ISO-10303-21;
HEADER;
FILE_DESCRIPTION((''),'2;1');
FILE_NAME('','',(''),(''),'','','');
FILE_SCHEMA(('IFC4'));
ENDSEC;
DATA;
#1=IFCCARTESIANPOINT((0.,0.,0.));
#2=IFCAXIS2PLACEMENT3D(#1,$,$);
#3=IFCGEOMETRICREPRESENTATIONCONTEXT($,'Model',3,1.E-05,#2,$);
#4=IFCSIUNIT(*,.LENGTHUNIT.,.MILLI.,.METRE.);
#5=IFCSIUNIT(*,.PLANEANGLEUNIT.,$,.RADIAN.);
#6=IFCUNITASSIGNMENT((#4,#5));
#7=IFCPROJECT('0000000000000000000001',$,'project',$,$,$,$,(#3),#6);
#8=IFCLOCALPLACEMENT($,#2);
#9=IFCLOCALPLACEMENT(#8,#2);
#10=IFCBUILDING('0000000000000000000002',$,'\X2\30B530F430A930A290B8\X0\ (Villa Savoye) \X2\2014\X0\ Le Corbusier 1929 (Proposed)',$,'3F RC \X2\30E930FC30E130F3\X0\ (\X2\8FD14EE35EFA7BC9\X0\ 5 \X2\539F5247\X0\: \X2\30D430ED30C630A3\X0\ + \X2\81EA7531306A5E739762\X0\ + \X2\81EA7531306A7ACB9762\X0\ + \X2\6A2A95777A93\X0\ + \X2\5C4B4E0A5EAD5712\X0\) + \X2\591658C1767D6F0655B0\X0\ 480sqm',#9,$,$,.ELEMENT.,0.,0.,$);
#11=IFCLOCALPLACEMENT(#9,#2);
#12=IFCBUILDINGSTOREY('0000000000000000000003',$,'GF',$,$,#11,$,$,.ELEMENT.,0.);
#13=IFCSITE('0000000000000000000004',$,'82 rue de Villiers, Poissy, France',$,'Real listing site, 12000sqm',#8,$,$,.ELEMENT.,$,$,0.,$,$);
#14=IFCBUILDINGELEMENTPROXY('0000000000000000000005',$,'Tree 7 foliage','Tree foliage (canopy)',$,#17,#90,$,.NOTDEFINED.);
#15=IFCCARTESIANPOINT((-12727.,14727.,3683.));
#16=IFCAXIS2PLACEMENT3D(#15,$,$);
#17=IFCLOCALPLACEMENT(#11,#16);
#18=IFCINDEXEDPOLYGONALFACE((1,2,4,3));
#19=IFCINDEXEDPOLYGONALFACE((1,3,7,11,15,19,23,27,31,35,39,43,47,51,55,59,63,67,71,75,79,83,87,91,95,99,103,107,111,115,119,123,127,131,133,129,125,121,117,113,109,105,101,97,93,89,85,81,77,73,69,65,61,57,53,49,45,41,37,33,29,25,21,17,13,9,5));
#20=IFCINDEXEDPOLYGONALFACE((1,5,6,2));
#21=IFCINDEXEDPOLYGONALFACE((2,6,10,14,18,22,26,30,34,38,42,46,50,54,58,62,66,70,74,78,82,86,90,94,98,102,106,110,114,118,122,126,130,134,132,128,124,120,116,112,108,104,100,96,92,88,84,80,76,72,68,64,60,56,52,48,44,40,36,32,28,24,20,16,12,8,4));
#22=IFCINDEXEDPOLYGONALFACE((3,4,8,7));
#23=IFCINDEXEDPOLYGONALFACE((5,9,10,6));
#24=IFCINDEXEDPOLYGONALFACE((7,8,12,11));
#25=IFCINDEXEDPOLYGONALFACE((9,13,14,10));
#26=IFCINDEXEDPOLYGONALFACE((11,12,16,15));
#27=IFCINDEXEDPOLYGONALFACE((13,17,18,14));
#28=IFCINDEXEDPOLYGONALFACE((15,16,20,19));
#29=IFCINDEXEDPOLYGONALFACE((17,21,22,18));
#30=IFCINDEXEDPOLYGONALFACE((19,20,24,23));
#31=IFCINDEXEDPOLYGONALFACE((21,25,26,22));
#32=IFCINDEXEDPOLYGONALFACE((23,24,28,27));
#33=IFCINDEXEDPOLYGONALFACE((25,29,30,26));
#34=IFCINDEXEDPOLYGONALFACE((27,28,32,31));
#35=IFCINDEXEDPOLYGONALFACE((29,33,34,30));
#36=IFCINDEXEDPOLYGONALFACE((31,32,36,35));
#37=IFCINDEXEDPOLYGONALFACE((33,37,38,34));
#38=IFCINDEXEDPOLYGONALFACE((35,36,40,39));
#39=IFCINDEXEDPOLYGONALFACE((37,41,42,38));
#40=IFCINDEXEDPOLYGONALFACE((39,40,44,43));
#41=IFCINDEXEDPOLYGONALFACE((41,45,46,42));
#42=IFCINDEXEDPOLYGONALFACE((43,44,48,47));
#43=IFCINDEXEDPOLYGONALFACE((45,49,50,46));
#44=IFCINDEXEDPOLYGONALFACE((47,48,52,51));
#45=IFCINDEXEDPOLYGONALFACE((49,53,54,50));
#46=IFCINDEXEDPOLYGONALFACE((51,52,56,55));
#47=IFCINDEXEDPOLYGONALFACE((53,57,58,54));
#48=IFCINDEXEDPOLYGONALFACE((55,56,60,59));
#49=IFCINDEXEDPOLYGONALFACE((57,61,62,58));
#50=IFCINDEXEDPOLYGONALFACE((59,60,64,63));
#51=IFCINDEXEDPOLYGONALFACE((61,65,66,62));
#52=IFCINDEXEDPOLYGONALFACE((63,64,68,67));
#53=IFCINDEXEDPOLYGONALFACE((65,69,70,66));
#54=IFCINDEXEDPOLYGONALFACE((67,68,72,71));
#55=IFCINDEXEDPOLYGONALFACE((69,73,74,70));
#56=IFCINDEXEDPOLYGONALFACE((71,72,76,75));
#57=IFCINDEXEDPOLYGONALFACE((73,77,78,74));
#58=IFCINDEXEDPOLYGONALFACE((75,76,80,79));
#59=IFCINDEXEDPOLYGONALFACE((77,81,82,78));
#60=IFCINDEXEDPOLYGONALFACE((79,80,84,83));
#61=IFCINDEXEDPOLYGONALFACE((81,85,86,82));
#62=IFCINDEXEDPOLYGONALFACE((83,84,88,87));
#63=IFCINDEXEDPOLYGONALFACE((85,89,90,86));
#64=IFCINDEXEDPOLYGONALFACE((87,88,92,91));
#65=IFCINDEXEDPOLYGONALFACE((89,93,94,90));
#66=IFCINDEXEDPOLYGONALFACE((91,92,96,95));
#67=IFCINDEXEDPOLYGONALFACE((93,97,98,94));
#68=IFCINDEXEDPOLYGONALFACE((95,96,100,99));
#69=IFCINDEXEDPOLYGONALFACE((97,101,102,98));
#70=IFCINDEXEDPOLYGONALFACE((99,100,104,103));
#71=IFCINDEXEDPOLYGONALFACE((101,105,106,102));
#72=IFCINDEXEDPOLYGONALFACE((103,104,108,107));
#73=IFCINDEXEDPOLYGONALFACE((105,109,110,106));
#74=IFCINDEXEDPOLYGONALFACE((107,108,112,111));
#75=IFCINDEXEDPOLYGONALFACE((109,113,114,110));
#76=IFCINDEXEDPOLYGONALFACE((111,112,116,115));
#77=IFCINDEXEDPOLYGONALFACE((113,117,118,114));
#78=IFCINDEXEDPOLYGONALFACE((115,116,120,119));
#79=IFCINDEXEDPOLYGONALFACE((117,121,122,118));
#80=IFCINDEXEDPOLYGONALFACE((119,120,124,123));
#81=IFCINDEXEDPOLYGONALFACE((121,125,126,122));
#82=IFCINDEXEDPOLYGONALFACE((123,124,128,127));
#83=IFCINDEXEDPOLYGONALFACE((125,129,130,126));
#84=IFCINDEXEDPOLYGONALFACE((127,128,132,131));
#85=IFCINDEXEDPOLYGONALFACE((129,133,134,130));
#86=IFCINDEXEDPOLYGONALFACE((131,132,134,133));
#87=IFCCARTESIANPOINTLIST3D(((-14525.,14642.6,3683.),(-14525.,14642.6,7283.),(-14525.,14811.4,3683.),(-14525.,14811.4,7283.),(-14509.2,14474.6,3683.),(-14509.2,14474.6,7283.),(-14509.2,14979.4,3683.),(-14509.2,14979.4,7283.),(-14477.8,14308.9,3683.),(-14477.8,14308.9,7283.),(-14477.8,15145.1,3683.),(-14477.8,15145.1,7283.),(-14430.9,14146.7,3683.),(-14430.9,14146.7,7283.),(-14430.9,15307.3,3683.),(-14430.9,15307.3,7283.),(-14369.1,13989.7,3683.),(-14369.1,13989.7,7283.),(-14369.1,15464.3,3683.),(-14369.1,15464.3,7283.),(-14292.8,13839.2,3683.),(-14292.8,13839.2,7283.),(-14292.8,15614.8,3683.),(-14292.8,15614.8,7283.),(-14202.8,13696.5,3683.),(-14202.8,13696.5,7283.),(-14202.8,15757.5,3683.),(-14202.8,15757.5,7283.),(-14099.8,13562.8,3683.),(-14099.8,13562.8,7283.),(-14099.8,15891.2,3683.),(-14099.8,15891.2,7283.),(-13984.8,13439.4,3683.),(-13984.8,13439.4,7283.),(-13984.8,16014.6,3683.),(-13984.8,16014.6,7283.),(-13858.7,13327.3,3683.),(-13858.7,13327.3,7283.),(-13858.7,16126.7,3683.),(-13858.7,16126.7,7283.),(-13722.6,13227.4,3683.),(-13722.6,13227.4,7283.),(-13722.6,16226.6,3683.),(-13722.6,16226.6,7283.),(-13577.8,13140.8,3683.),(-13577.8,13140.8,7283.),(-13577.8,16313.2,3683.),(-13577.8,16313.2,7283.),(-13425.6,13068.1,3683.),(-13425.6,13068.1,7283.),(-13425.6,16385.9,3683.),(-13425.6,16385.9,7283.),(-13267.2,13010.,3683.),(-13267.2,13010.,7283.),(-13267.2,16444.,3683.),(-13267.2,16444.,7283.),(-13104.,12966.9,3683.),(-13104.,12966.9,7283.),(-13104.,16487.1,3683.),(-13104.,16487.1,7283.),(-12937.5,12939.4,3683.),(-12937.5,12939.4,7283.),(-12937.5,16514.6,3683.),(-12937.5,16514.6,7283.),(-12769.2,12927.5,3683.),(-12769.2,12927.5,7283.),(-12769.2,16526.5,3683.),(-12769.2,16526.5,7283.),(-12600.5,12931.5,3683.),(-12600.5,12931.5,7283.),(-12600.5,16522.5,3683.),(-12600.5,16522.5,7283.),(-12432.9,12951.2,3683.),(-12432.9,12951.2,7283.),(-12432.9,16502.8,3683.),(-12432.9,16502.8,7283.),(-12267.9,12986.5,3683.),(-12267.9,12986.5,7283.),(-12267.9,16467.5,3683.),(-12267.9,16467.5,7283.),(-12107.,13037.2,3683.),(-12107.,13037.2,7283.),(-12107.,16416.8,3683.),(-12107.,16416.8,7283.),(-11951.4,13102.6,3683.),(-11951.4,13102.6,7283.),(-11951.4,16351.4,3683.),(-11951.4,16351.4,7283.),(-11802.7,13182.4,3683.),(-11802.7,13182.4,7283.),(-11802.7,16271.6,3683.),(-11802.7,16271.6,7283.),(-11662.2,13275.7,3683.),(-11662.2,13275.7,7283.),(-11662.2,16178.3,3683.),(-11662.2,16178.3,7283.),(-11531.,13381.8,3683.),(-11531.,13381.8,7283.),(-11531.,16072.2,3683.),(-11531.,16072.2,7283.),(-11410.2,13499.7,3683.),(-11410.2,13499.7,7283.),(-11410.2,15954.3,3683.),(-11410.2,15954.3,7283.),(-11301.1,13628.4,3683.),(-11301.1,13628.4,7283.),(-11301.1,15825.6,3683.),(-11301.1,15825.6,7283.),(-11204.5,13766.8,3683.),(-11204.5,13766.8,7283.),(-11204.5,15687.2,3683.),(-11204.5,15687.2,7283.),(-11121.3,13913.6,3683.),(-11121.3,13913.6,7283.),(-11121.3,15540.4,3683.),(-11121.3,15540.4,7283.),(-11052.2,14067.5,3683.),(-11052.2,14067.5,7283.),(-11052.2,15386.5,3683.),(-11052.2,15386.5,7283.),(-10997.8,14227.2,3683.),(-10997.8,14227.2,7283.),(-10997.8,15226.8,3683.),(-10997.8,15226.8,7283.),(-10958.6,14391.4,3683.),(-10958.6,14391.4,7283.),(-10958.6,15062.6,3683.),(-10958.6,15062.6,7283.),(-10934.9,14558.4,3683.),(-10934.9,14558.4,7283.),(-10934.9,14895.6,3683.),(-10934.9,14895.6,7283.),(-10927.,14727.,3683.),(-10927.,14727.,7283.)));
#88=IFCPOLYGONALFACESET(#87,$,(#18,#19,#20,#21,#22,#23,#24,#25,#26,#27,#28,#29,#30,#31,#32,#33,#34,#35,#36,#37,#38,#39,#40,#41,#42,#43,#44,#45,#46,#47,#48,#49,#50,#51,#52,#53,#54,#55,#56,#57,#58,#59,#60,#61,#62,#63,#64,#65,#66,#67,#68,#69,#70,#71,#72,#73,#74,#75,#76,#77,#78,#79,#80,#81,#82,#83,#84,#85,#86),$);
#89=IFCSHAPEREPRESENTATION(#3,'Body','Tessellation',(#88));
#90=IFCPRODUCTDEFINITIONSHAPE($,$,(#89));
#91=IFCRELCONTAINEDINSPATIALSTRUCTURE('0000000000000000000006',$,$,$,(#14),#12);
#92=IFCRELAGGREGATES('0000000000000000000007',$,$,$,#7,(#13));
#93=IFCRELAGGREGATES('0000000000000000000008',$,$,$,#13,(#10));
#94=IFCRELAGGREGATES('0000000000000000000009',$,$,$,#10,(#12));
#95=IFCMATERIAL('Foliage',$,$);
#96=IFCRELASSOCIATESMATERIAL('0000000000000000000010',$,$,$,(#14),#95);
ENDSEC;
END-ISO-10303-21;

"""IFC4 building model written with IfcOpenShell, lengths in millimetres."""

from ifc_helpers import new_model, si_unit, frame, origin, origin_2d, place, context, project, spatial, circle, extrude, material, element, save


model = new_model("IFC4")

# Units and contexts
model_context = context("Model", 3, precision=1e-05, world=origin())
ifc_project = project(units=[si_unit("LENGTHUNIT", "METRE", prefix="MILLI"), si_unit("PLANEANGLEUNIT", "RADIAN")], contexts=[model_context])

# Site, building, storey
site_placement = place(None, origin())
site = spatial("IfcSite", under=ifc_project, at=site_placement, Name="82 rue de Villiers, Poissy, France", ObjectType="Real listing site, 12000sqm", CompositionType="ELEMENT", RefElevation=0.0)
building_placement = place(site_placement, origin())
building = spatial("IfcBuilding", under=site, at=building_placement, Name="サヴォア邸 (Villa Savoye) — Le Corbusier 1929 (Proposed)", ObjectType="3F RC ラーメン (近代建築 5 原則: ピロティ + 自由な平面 + 自由な立面 + 横長窓 + 屋上庭園) + 外壁白漆喰 480sqm", CompositionType="ELEMENT", ElevationOfRefHeight=0.0, ElevationOfTerrain=0.0)
storey_placement = place(building_placement, origin())
storey = spatial("IfcBuildingStorey", under=building, at=storey_placement, Name="GF", CompositionType="ELEMENT", Elevation=0.0)

# Building element proxy
ifc_material_1 = material(Name="Foliage")
proxy_1_placement = place(storey_placement, frame((-12727.0, 14727.0, 3683.0)))
element("IfcBuildingElementProxy", 1, at=proxy_1_placement, inside=storey, material=ifc_material_1, Name="Tree 7 foliage", Description="Tree foliage (canopy)", PredefinedType="NOTDEFINED", context=model_context, shape_type="SweptSolid", body=[
    extrude(circle(Radius=1800.0, at=origin_2d()), frame((-12727.0, 14727.0, 3683.0)), (0.0, 0.0, 1.0), 3600.0),
])

save(model, "model.ifc")
